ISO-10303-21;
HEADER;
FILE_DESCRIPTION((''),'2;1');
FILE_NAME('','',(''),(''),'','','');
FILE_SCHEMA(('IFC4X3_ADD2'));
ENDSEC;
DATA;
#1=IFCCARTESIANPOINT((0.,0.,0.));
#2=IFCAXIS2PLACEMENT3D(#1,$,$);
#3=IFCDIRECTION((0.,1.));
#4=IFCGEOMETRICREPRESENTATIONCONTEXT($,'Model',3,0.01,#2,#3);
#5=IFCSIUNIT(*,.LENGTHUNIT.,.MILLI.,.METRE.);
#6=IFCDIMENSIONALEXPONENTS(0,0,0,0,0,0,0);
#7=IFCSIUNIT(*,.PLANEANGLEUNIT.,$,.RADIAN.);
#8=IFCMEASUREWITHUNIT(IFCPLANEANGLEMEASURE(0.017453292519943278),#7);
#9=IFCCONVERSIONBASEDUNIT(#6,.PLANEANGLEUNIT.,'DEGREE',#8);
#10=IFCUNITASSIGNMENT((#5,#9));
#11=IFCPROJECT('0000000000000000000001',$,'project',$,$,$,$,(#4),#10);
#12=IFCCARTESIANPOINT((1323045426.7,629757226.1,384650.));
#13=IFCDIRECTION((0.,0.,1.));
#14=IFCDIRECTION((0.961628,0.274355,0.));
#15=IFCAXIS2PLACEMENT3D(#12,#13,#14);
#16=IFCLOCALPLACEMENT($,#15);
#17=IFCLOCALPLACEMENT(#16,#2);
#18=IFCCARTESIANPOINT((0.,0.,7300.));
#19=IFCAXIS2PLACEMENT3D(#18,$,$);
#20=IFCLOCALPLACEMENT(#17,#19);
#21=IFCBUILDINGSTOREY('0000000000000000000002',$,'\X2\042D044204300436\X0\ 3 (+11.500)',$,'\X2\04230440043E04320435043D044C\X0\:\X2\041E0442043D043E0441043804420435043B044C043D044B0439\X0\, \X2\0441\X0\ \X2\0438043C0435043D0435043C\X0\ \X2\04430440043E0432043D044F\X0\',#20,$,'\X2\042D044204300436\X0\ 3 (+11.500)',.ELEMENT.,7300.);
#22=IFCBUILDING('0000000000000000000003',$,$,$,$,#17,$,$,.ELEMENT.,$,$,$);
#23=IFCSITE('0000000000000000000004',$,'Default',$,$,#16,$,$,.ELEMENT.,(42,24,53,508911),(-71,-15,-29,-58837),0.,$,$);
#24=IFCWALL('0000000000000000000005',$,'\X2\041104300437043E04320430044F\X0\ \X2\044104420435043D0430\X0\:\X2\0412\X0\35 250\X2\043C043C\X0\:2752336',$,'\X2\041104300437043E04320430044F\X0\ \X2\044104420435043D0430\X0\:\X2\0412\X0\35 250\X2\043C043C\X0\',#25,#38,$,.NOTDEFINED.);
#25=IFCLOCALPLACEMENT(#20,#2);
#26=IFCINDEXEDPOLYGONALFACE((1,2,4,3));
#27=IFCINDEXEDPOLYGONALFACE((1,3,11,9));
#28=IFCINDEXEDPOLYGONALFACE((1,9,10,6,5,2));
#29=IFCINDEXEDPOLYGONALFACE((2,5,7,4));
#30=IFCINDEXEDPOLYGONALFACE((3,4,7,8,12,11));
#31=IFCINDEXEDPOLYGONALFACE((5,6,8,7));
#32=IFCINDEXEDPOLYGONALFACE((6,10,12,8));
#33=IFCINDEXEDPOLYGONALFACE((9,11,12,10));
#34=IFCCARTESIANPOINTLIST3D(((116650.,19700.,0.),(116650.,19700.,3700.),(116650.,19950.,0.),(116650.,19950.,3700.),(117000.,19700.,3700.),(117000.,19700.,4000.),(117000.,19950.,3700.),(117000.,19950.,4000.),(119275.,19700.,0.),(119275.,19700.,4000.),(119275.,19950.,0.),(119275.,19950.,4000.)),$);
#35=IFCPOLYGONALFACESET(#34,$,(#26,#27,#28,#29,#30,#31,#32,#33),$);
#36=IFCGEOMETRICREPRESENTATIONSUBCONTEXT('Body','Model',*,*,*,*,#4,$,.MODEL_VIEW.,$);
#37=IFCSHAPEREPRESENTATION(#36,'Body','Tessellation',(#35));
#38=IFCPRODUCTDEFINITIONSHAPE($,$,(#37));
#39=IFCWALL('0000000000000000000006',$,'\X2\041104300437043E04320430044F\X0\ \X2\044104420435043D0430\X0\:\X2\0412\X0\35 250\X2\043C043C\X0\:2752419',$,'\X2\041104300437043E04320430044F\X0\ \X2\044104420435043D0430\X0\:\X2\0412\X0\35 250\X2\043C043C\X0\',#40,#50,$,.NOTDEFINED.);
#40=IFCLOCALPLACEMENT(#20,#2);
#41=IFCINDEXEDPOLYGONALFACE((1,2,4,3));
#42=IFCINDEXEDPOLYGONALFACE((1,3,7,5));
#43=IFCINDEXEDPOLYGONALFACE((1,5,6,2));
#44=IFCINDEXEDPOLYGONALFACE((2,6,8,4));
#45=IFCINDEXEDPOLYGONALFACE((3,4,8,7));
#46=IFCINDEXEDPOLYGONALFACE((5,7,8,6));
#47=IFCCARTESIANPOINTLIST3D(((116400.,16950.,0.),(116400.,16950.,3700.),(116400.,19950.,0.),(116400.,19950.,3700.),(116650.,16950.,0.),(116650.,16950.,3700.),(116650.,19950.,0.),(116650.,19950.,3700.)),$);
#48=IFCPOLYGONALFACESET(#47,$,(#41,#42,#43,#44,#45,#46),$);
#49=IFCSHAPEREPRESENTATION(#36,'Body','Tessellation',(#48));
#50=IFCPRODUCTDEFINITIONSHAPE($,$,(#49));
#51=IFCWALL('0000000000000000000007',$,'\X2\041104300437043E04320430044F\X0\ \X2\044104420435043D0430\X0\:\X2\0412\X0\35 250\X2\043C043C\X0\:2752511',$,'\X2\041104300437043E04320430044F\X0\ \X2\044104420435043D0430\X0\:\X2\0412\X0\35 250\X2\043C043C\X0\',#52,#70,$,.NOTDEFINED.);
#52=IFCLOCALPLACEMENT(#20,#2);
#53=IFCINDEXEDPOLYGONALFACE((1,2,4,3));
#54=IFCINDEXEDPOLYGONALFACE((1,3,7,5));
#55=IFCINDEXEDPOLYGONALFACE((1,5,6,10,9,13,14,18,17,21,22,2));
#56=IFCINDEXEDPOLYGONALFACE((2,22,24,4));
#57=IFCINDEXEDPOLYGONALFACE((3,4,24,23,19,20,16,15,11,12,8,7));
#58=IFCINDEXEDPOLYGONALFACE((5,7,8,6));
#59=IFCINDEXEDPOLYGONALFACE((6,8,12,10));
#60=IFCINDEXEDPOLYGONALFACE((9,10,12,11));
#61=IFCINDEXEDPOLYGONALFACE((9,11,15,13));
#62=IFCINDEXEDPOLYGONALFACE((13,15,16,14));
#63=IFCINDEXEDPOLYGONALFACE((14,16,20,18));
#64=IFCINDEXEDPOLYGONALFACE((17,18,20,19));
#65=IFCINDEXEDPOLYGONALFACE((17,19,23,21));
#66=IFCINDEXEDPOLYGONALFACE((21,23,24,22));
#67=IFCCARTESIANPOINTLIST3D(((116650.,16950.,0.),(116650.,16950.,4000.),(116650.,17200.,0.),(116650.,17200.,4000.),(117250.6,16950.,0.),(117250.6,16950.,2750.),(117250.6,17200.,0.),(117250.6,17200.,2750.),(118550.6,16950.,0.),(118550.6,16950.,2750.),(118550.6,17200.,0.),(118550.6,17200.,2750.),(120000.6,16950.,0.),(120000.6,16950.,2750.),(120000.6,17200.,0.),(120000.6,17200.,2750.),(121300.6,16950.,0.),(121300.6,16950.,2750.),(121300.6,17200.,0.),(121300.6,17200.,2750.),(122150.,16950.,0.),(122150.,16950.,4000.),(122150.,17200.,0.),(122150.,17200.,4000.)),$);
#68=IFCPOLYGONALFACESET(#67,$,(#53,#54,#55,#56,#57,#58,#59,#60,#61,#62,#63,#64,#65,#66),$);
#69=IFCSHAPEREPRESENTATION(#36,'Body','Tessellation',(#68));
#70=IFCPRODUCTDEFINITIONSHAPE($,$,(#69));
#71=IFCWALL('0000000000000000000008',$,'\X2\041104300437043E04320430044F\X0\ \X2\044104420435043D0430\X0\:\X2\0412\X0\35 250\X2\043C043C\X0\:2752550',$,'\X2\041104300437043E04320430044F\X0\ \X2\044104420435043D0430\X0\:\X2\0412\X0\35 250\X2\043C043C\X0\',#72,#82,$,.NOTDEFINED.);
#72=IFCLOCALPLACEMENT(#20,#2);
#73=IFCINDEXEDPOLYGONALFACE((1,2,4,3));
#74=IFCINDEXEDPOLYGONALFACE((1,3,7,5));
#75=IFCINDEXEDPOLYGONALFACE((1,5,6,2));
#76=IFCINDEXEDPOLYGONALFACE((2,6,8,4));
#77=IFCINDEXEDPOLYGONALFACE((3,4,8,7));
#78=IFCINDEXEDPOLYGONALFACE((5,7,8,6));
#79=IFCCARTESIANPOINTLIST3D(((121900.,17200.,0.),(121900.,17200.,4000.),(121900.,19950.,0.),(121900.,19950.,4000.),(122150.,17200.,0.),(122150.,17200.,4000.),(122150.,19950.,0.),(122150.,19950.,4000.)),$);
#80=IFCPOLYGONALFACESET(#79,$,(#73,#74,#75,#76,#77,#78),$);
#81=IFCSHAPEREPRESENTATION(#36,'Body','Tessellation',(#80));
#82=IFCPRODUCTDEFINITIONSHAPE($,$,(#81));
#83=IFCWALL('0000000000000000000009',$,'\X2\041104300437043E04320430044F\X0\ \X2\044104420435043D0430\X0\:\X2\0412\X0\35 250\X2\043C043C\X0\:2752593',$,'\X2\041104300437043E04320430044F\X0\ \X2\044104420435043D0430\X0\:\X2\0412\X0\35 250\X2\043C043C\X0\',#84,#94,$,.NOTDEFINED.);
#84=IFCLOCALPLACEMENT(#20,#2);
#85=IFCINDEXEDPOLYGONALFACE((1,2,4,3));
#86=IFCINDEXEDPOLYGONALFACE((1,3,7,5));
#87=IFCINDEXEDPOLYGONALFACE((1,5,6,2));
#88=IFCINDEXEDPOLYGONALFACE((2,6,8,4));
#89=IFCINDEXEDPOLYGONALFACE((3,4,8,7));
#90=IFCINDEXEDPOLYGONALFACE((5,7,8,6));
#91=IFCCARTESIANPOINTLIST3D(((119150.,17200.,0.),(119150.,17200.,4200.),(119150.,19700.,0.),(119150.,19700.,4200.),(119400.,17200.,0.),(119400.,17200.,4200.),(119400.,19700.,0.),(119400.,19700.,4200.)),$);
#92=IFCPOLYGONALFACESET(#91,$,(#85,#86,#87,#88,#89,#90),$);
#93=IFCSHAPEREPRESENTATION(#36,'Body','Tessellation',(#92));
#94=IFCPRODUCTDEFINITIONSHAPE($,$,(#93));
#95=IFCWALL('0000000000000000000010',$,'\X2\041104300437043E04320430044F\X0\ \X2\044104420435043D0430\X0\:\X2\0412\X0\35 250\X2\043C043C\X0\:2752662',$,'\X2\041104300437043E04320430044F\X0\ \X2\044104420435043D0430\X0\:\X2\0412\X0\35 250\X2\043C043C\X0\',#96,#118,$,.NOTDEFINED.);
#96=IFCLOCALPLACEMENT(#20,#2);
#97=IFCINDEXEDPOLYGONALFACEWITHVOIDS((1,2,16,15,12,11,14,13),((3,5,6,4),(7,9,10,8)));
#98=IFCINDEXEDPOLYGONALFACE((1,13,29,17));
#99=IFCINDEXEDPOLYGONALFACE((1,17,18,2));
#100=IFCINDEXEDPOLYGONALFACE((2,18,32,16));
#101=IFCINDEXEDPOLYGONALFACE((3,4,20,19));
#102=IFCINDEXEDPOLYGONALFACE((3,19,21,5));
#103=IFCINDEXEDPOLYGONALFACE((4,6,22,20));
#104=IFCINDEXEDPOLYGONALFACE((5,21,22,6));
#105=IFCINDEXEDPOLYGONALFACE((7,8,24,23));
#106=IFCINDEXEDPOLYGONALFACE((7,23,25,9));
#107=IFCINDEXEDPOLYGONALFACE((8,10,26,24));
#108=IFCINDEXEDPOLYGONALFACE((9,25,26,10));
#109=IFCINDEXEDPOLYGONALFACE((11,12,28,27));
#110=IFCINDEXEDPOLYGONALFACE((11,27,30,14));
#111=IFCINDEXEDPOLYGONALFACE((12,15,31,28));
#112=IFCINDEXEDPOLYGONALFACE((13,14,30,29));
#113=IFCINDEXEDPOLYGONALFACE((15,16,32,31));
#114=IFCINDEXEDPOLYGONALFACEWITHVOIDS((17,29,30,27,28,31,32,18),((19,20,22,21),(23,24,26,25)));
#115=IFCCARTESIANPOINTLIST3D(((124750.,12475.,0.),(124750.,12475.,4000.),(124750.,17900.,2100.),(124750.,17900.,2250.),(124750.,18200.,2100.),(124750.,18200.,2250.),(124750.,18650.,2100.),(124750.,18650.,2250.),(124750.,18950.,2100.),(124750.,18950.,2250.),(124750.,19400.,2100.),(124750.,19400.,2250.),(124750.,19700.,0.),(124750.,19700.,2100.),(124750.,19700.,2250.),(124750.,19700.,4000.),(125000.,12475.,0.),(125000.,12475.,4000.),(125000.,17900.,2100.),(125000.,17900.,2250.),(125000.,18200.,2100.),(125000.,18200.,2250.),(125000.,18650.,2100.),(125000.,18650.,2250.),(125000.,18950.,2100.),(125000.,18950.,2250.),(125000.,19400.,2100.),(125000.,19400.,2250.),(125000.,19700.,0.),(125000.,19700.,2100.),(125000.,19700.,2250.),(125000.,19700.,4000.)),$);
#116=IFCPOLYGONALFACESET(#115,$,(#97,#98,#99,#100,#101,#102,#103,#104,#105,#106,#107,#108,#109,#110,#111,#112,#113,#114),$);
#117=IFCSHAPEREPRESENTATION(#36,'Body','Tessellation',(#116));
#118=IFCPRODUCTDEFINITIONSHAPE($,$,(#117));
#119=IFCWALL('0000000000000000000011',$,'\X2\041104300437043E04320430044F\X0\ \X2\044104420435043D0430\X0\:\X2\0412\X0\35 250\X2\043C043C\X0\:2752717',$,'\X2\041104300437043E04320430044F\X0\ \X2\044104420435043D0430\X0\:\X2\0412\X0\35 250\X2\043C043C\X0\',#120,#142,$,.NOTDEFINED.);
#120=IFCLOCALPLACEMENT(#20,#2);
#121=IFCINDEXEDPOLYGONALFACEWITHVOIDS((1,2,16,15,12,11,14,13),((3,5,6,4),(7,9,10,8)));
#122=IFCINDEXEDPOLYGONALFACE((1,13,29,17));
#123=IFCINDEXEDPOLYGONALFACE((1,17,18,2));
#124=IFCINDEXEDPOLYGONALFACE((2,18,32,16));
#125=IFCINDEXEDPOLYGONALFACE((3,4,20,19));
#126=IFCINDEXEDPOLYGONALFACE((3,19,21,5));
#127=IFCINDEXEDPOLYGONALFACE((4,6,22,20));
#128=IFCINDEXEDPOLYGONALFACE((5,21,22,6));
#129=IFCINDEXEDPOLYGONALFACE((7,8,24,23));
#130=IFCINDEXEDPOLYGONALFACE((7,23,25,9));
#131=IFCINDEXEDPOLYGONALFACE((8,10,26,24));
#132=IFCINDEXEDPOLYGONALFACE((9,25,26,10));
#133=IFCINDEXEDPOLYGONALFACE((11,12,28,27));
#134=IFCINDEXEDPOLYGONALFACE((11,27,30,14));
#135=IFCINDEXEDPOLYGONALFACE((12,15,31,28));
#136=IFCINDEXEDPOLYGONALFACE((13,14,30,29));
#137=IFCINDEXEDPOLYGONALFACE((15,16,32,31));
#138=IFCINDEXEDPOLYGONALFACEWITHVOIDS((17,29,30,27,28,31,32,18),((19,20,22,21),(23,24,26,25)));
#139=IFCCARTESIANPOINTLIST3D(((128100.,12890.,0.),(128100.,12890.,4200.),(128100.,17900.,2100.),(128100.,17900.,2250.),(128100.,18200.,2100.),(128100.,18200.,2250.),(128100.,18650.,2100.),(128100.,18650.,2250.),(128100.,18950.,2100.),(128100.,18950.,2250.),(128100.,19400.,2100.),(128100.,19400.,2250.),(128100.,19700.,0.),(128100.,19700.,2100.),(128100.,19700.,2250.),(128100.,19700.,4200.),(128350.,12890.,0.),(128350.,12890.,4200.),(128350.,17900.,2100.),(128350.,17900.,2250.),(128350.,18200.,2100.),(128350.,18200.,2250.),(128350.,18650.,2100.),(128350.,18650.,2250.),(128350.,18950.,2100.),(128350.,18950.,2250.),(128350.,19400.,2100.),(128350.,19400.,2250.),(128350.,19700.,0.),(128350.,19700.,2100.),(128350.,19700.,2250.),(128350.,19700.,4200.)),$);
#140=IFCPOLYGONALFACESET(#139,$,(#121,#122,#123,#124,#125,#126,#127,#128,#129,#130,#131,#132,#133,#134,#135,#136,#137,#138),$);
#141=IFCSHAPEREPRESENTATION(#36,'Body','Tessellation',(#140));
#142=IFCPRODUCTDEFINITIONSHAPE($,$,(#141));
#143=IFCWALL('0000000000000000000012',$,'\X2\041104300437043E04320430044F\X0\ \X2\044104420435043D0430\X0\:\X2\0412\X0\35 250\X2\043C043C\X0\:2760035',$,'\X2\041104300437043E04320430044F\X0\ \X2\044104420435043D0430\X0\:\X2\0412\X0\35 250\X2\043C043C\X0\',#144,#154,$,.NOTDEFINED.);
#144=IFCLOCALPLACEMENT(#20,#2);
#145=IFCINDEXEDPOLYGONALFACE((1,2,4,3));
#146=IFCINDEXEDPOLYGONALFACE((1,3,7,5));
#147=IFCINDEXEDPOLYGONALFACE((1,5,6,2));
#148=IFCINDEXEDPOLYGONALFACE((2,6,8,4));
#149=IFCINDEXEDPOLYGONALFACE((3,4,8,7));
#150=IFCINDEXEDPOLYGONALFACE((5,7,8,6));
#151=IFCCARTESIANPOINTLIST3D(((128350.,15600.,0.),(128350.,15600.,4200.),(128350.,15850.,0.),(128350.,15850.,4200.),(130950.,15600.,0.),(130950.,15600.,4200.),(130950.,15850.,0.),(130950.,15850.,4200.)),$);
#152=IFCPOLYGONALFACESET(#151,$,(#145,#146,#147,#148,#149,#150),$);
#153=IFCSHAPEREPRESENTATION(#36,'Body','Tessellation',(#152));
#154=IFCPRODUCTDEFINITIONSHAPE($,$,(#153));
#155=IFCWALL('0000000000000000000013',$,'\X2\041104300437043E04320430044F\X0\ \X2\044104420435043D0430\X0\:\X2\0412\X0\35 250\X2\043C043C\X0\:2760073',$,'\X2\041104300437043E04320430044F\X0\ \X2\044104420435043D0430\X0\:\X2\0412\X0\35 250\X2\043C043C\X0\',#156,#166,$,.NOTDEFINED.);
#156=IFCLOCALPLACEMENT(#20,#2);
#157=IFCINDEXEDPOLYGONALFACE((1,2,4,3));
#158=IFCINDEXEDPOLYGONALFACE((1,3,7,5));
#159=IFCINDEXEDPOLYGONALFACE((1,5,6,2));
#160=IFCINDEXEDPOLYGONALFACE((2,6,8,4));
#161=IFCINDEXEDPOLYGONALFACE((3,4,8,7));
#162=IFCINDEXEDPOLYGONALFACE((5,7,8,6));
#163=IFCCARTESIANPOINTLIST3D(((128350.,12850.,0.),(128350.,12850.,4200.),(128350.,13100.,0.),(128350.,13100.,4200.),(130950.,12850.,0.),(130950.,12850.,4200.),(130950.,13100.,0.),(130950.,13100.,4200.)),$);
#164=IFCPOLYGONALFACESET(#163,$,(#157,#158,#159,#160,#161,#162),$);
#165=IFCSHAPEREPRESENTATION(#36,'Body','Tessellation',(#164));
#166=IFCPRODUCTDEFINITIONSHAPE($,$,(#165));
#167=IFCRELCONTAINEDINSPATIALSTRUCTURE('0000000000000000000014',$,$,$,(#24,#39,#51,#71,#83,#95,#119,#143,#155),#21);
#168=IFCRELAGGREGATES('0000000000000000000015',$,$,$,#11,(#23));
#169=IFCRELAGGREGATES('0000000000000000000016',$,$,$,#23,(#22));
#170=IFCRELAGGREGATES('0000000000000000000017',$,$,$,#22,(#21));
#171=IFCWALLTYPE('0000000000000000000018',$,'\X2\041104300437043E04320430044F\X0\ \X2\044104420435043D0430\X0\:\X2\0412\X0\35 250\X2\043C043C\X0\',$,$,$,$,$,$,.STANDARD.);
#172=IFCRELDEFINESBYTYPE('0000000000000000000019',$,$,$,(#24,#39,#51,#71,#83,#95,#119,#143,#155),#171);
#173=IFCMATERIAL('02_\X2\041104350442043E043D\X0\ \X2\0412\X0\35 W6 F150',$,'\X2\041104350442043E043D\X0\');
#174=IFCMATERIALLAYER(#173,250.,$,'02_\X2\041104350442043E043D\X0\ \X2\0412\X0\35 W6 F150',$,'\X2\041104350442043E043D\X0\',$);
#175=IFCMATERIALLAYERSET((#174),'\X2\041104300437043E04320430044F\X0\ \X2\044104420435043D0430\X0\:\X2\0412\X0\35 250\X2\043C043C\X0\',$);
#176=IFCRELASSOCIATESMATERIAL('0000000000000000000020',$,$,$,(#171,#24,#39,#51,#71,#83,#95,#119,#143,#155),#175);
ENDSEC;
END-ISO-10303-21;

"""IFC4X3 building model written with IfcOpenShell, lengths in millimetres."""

from ifc_helpers import new_model, entity, si_unit, converted_unit, direction, frame, frame_2d, origin, place, context, subcontext, project, spatial, rectangle, extrude, material, layer, layer_set, type_object, element, save


model = new_model("IFC4X3")

# Units and contexts
model_context = context("Model", 3, precision=0.01, world=origin(), true_north=direction((0.0, 1.0)))
body_context = subcontext(model_context, "Body", "Model", "MODEL_VIEW")
ifc_project = project(units=[si_unit("LENGTHUNIT", "METRE", prefix="MILLI"), converted_unit("PLANEANGLEUNIT", "DEGREE", entity("IfcPlaneAngleMeasure", 0.017453292519943278), si_unit("PLANEANGLEUNIT", "RADIAN"), dimensions=[0, 0, 0, 0, 0, 0, 0])], contexts=[model_context])

# Site, building, storey
site_placement = place(None, frame((1323045426.7, 629757226.1, 384650.0), z_axis=(0.0, 0.0, 1.0), x_axis=(0.961628, 0.274355, 0.0)))
site = spatial("IfcSite", under=ifc_project, at=site_placement, Name="Default", CompositionType="ELEMENT", RefLatitude=(42, 24, 53, 508911), RefLongitude=(-71, -15, -29, -58837), RefElevation=0.0)
building_placement = place(site_placement, origin())
building = spatial("IfcBuilding", under=site, at=building_placement, CompositionType="ELEMENT")
storey_placement = place(building_placement, frame((0.0, 0.0, 7300.0)))
storey = spatial("IfcBuildingStorey", under=building, at=storey_placement, Name="Этаж 3 (+11.500)", ObjectType="Уровень:Относительный, с именем уровня", LongName="Этаж 3 (+11.500)", CompositionType="ELEMENT", Elevation=7300.0)

# Wall, opening
ifc_material = material(Name="02_Бетон В35 W6 F150", Category="Бетон")
ifc_layer_1 = layer(ifc_material, 250.0, Name="02_Бетон В35 W6 F150", Category="Бетон")
ifc_layer_set_1 = layer_set([ifc_layer_1], Name="Базовая стена:В35 250мм")
wall_type_1 = type_object("IfcWallType", Name="Базовая стена:В35 250мм", PredefinedType="STANDARD", material=ifc_layer_set_1)
wall_1_placement = place(storey_placement, frame((116650.0, 19825.0, 0.0)))
wall_1 = element("IfcWall", 1, at=wall_1_placement, inside=storey, type_object=wall_type_1, material=ifc_layer_set_1, Name="Базовая стена:В35 250мм:2752336", ObjectType="Базовая стена:В35 250мм", PredefinedType="NOTDEFINED", context=body_context, shape_type="SweptSolid", body=[
    extrude(rectangle(XDim=2625.0, YDim=250.0, at=frame_2d((1312.5, 0.0), x_axis=(-1.0, 0.0))), origin(), (0.0, 0.0, 1.0), 4000.0),
])
opening_1_placement = place(wall_1_placement, origin())
element("IfcOpeningElement", 2, at=opening_1_placement, cuts=wall_1, PredefinedType="OPENING", context=body_context, shape_type="SweptSolid", body=[
    extrude(rectangle(XDim=300.0, YDim=350.0, at=frame_2d((0.0, 0.0), x_axis=(0.0, 1.0))), frame((175.0, 125.0, 3850.0), z_axis=(0.0, -1.0, 0.0), x_axis=(-1.0, 0.0, 0.0)), (0.0, 0.0, 1.0), 250.0),
])

# Wall
wall_2_placement = place(storey_placement, frame((116525.0, 16950.0, 0.0), z_axis=(0.0, 0.0, 1.0), x_axis=(0.0, 1.0, 0.0)))
element("IfcWall", 3, at=wall_2_placement, inside=storey, type_object=wall_type_1, material=ifc_layer_set_1, Name="Базовая стена:В35 250мм:2752419", ObjectType="Базовая стена:В35 250мм", PredefinedType="NOTDEFINED", context=body_context, shape_type="SweptSolid", body=[
    extrude(rectangle(XDim=3000.0, YDim=250.0, at=frame_2d((1500.0, 0.0), x_axis=(-1.0, 0.0))), origin(), (0.0, 0.0, 1.0), 3700.0),
])

# Wall, openings
wall_3_placement = place(storey_placement, frame((116650.0, 17075.0, 0.0)))
wall_3 = element("IfcWall", 4, at=wall_3_placement, inside=storey, type_object=wall_type_1, material=ifc_layer_set_1, Name="Базовая стена:В35 250мм:2752511", ObjectType="Базовая стена:В35 250мм", PredefinedType="NOTDEFINED", context=body_context, shape_type="SweptSolid", body=[
    extrude(rectangle(XDim=5500.0, YDim=250.0, at=frame_2d((2750.0, 0.0), x_axis=(-1.0, 0.0))), origin(), (0.0, 0.0, 1.0), 4000.0),
])
opening_2_placement = place(wall_3_placement, frame((-116650.0, -17075.0, 0.0)))
element("IfcOpeningElement", 5, at=opening_2_placement, cuts=wall_3, PredefinedType="OPENING", context=body_context, shape_type="SweptSolid", body=[
    extrude(rectangle(XDim=2750.0, YDim=1300.0, at=frame_2d((0.0, 0.0), x_axis=(1.0, 0.0))), frame((117900.6, 15426.0, 1375.0), z_axis=(0.0, 1.0, 0.0), x_axis=(0.0, 0.0, -1.0)), (0.0, 0.0, 1.0), 3048.0),
])
opening_3_placement = place(wall_3_placement, frame((-116650.0, -17075.0, 0.0)))
element("IfcOpeningElement", 6, at=opening_3_placement, cuts=wall_3, PredefinedType="OPENING", context=body_context, shape_type="SweptSolid", body=[
    extrude(rectangle(XDim=2750.0, YDim=1300.0, at=frame_2d((0.0, 0.0), x_axis=(1.0, 0.0))), frame((120650.6, 15426.0, 1375.0), z_axis=(0.0, 1.0, 0.0), x_axis=(0.0, 0.0, -1.0)), (0.0, 0.0, 1.0), 3048.0),
])

# Walls
wall_4_placement = place(storey_placement, frame((122025.0, 17200.0, 0.0), z_axis=(0.0, 0.0, 1.0), x_axis=(0.0, 1.0, 0.0)))
element("IfcWall", 7, at=wall_4_placement, inside=storey, type_object=wall_type_1, material=ifc_layer_set_1, Name="Базовая стена:В35 250мм:2752550", ObjectType="Базовая стена:В35 250мм", PredefinedType="NOTDEFINED", context=body_context, shape_type="SweptSolid", body=[
    extrude(rectangle(XDim=2750.0, YDim=250.0, at=frame_2d((1375.0, 0.0), x_axis=(-1.0, 0.0))), origin(), (0.0, 0.0, 1.0), 4000.0),
])
wall_5_placement = place(storey_placement, frame((119275.0, 17200.0, 0.0), z_axis=(0.0, 0.0, 1.0), x_axis=(0.0, 1.0, 0.0)))
element("IfcWall", 8, at=wall_5_placement, inside=storey, type_object=wall_type_1, material=ifc_layer_set_1, Name="Базовая стена:В35 250мм:2752593", ObjectType="Базовая стена:В35 250мм", PredefinedType="NOTDEFINED", context=body_context, shape_type="SweptSolid", body=[
    extrude(rectangle(XDim=2500.0, YDim=250.0, at=frame_2d((1250.0, 0.0), x_axis=(-1.0, 0.0))), origin(), (0.0, 0.0, 1.0), 4200.0),
])

# Walls, openings
wall_6_placement = place(storey_placement, frame((124875.0, 19700.0, 0.0), z_axis=(0.0, 0.0, 1.0), x_axis=(0.0, -1.0, 0.0)))
wall_6 = element("IfcWall", 9, at=wall_6_placement, inside=storey, type_object=wall_type_1, material=ifc_layer_set_1, Name="Базовая стена:В35 250мм:2752662", ObjectType="Базовая стена:В35 250мм", PredefinedType="NOTDEFINED", context=body_context, shape_type="SweptSolid", body=[
    extrude(rectangle(XDim=7225.0, YDim=250.0, at=frame_2d((3612.5, 0.0), x_axis=(-1.0, 0.0))), origin(), (0.0, 0.0, 1.0), 4000.0),
])
opening_4_placement = place(wall_6_placement, frame((19700.0, -124875.0, 2100.0), z_axis=(0.0, 0.0, 1.0), x_axis=(0.0, 1.0, 0.0)))
element("IfcOpeningElement", 10, at=opening_4_placement, cuts=wall_6, PredefinedType="OPENING", context=body_context, shape_type="SweptSolid", body=[
    extrude(rectangle(XDim=150.0, YDim=300.0, at=frame_2d((0.0, 0.0), x_axis=(0.0, 1.0))), frame((123226.0, 19550.0, 75.0), z_axis=(1.0, 0.0, 0.0), x_axis=(0.0, -1.0, 0.0)), (0.0, 0.0, 1.0), 3048.0),
])
opening_5_placement = place(wall_6_placement, frame((19700.0, -124875.0, 2100.0), z_axis=(0.0, 0.0, 1.0), x_axis=(0.0, 1.0, 0.0)))
element("IfcOpeningElement", 11, at=opening_5_placement, cuts=wall_6, PredefinedType="OPENING", context=body_context, shape_type="SweptSolid", body=[
    extrude(rectangle(XDim=150.0, YDim=300.0, at=frame_2d((0.0, 0.0), x_axis=(0.0, 1.0))), frame((123226.0, 18800.0, 75.0), z_axis=(1.0, 0.0, 0.0), x_axis=(0.0, -1.0, 0.0)), (0.0, 0.0, 1.0), 3048.0),
])
opening_6_placement = place(wall_6_placement, frame((19700.0, -124875.0, 2100.0), z_axis=(0.0, 0.0, 1.0), x_axis=(0.0, 1.0, 0.0)))
element("IfcOpeningElement", 12, at=opening_6_placement, cuts=wall_6, PredefinedType="OPENING", context=body_context, shape_type="SweptSolid", body=[
    extrude(rectangle(XDim=150.0, YDim=300.0, at=frame_2d((0.0, 0.0), x_axis=(0.0, 1.0))), frame((123226.0, 18050.0, 75.0), z_axis=(1.0, 0.0, 0.0), x_axis=(0.0, -1.0, 0.0)), (0.0, 0.0, 1.0), 3048.0),
])
wall_7_placement = place(storey_placement, frame((128225.0, 19700.0, 0.0), z_axis=(0.0, 0.0, 1.0), x_axis=(0.0, -1.0, 0.0)))
wall_7 = element("IfcWall", 13, at=wall_7_placement, inside=storey, type_object=wall_type_1, material=ifc_layer_set_1, Name="Базовая стена:В35 250мм:2752717", ObjectType="Базовая стена:В35 250мм", PredefinedType="NOTDEFINED", context=body_context, shape_type="SweptSolid", body=[
    extrude(rectangle(XDim=6810.0, YDim=250.0, at=frame_2d((3405.0, 0.0), x_axis=(-1.0, 0.0))), origin(), (0.0, 0.0, 1.0), 4200.0),
])
opening_7_placement = place(wall_7_placement, frame((19700.0, -128225.0, 2100.0), z_axis=(0.0, 0.0, 1.0), x_axis=(0.0, 1.0, 0.0)))
element("IfcOpeningElement", 14, at=opening_7_placement, cuts=wall_7, PredefinedType="OPENING", context=body_context, shape_type="SweptSolid", body=[
    extrude(rectangle(XDim=150.0, YDim=300.0, at=frame_2d((0.0, 0.0), x_axis=(1.0, 0.0))), frame((126826.0, 19550.0, 75.0), z_axis=(1.0, 0.0, 0.0), x_axis=(0.0, 0.0, -1.0)), (0.0, 0.0, 1.0), 3048.0),
])
opening_8_placement = place(wall_7_placement, frame((19700.0, -128225.0, 2100.0), z_axis=(0.0, 0.0, 1.0), x_axis=(0.0, 1.0, 0.0)))
element("IfcOpeningElement", 15, at=opening_8_placement, cuts=wall_7, PredefinedType="OPENING", context=body_context, shape_type="SweptSolid", body=[
    extrude(rectangle(XDim=150.0, YDim=300.0, at=frame_2d((0.0, 0.0), x_axis=(1.0, 0.0))), frame((126826.0, 18800.0, 75.0), z_axis=(1.0, 0.0, 0.0), x_axis=(0.0, 0.0, -1.0)), (0.0, 0.0, 1.0), 3048.0),
])
opening_9_placement = place(wall_7_placement, frame((19700.0, -128225.0, 2100.0), z_axis=(0.0, 0.0, 1.0), x_axis=(0.0, 1.0, 0.0)))
element("IfcOpeningElement", 16, at=opening_9_placement, cuts=wall_7, PredefinedType="OPENING", context=body_context, shape_type="SweptSolid", body=[
    extrude(rectangle(XDim=150.0, YDim=300.0, at=frame_2d((0.0, 0.0), x_axis=(1.0, 0.0))), frame((126826.0, 18050.0, 75.0), z_axis=(1.0, 0.0, 0.0), x_axis=(0.0, 0.0, -1.0)), (0.0, 0.0, 1.0), 3048.0),
])

# Walls
for number, where, z_axis, x_axis, name in (
    (17, (130950.0, 15725.0, 0.0), (0.0, 0.0, 1.0), (-1.0, 0.0, 0.0), "Базовая стена:В35 250мм:2760035"),
    (18, (130950.0, 12975.0, 0.0), (0.0, 0.0, 1.0), (-1.0, 0.0, 0.0), "Базовая стена:В35 250мм:2760073"),
):
    element("IfcWall", number, at=place(storey_placement, frame(where, z_axis=z_axis, x_axis=x_axis)), inside=storey, type_object=wall_type_1, material=ifc_layer_set_1, Name=name, ObjectType="Базовая стена:В35 250мм", PredefinedType="NOTDEFINED", context=body_context, shape_type="SweptSolid", body=[
        extrude(rectangle(XDim=2600.0, YDim=250.0, at=frame_2d((1300.0, 0.0), x_axis=(-1.0, 0.0))), origin(), (0.0, 0.0, 1.0), 4200.0),
    ])

save(model, "model.ifc")
